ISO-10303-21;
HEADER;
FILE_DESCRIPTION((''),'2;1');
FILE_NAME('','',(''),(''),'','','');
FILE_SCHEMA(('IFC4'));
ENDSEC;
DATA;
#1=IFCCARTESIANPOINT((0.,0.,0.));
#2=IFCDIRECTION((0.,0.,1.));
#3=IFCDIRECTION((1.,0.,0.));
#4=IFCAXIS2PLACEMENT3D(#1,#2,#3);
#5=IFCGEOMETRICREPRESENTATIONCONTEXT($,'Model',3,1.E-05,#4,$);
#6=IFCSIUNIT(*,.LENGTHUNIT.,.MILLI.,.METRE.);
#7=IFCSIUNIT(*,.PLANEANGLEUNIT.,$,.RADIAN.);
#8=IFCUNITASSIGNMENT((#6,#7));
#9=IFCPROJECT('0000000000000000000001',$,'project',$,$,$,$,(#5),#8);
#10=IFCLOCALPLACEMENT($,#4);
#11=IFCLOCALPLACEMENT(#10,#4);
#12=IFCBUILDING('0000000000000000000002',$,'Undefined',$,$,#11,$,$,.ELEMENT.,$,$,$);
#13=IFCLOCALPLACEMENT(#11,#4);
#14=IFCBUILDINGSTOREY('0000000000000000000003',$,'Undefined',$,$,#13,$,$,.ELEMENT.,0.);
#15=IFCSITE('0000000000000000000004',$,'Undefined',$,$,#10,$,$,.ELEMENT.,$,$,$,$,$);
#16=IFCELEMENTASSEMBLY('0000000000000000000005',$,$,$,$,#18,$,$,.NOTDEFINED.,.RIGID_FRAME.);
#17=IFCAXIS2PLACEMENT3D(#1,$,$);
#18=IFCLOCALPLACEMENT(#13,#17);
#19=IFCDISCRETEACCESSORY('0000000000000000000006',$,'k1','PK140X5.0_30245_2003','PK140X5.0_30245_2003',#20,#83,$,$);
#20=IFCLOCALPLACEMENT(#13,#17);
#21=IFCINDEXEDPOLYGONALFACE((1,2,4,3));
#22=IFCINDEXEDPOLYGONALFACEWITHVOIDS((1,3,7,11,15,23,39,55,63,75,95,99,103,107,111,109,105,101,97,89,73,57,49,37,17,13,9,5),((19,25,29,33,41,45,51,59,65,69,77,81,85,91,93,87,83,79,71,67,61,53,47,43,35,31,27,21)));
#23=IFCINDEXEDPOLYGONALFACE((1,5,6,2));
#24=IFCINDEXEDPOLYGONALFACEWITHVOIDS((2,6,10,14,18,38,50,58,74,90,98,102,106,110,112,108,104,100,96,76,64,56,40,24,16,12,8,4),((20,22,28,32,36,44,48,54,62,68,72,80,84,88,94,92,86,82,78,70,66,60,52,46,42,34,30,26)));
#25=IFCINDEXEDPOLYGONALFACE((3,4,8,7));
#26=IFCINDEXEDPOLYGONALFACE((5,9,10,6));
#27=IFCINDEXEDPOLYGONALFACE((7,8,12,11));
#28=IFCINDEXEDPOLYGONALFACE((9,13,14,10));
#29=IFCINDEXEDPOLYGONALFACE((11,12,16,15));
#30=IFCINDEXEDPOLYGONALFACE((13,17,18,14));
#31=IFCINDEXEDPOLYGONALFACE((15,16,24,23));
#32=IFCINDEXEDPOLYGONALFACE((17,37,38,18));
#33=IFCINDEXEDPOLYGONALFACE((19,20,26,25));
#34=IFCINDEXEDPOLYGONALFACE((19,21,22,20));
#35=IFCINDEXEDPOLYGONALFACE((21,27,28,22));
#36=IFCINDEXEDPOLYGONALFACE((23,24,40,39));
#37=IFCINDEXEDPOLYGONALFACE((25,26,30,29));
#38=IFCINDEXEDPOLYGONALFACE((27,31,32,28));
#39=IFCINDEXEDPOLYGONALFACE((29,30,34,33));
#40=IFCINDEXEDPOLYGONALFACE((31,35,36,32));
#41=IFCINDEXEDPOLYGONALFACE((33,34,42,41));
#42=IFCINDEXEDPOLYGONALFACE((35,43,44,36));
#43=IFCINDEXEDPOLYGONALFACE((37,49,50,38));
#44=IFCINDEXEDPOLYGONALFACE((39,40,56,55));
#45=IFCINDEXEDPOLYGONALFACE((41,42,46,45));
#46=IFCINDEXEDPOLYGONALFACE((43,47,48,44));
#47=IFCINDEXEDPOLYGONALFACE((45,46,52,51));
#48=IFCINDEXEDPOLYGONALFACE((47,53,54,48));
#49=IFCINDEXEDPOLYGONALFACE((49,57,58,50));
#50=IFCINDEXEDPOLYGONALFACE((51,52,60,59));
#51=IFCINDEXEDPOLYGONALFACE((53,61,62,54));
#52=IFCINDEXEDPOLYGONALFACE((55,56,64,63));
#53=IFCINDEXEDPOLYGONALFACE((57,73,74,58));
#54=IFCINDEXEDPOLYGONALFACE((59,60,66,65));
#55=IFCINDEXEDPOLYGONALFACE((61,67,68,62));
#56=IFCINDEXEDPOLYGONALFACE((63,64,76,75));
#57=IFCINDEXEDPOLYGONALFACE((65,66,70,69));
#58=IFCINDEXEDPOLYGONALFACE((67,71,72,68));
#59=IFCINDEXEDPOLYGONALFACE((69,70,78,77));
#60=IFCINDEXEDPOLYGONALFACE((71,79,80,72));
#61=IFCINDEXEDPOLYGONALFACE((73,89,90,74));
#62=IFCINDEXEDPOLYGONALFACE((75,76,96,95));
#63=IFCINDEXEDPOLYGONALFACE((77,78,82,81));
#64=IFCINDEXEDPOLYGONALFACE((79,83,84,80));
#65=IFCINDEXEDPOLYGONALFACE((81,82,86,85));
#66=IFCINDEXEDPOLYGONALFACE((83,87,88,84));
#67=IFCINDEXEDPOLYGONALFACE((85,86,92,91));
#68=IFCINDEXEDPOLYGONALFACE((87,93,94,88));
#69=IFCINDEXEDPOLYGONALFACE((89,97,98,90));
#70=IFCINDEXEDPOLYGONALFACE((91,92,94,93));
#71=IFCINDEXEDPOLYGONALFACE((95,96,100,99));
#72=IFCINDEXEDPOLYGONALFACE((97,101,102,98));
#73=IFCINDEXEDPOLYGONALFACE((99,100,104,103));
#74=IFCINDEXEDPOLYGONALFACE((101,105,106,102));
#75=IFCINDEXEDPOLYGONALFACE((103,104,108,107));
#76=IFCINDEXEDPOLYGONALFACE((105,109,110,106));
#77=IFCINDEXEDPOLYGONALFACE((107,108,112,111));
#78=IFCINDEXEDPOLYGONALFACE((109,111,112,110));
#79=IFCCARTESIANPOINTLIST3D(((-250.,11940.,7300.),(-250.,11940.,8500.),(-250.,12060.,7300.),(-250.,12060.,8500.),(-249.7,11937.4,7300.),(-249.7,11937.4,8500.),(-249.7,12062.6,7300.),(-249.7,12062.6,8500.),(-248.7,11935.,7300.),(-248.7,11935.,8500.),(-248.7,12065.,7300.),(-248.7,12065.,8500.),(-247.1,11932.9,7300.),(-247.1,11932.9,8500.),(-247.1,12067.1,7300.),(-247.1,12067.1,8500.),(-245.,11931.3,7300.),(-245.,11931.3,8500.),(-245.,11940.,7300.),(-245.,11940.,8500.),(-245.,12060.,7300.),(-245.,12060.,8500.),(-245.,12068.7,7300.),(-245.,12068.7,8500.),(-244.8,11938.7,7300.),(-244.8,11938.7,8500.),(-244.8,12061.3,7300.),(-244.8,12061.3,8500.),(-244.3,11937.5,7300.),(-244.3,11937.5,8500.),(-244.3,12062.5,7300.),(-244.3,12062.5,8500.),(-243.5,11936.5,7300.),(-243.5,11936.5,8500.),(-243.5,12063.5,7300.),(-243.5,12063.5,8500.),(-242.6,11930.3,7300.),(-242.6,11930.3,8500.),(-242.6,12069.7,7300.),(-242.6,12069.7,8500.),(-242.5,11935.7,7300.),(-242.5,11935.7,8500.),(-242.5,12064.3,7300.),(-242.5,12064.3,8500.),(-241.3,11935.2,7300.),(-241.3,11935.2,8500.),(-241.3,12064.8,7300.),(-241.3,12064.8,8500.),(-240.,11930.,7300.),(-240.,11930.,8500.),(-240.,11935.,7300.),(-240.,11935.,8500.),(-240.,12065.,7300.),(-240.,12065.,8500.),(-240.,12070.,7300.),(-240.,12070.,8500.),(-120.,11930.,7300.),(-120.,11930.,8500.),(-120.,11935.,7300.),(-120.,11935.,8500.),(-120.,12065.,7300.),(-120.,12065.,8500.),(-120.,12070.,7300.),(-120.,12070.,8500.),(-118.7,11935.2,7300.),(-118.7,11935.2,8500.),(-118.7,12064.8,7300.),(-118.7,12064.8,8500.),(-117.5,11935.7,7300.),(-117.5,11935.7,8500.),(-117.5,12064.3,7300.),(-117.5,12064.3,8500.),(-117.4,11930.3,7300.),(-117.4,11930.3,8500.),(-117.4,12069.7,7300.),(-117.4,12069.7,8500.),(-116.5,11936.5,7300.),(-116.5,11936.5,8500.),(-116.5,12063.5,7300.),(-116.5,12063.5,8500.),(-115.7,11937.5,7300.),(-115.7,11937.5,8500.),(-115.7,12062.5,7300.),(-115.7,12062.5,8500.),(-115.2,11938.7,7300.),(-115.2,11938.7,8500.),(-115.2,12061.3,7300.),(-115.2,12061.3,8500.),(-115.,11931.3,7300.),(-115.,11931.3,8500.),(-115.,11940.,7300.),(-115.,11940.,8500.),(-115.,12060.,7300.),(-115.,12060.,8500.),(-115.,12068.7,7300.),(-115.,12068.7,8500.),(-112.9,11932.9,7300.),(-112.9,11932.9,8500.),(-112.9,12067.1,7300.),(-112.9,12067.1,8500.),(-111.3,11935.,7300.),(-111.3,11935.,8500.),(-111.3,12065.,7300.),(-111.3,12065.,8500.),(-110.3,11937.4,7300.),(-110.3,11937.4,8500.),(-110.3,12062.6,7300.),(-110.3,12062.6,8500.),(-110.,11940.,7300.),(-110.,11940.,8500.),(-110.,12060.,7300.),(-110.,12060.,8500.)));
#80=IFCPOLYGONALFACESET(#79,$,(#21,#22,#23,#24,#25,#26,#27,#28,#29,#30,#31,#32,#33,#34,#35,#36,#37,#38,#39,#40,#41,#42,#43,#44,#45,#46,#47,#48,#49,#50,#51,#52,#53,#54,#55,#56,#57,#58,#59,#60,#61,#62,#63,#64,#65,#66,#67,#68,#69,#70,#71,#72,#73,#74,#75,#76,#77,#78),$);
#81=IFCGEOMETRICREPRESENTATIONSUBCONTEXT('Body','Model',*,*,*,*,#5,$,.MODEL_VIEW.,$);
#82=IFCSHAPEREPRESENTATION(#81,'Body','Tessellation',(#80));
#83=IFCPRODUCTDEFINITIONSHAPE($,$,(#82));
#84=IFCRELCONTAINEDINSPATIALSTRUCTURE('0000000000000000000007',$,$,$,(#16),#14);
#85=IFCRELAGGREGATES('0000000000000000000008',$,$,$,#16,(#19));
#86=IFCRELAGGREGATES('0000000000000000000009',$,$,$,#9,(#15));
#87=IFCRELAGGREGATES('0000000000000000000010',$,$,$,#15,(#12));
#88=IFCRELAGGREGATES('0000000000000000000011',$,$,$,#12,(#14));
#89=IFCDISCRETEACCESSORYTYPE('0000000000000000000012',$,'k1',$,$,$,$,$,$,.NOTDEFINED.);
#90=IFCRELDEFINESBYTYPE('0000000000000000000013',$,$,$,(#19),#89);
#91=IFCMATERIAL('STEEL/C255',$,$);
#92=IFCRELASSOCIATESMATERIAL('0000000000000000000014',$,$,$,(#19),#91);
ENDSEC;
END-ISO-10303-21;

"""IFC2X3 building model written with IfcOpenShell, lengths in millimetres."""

from ifc_helpers import new_model, si_unit, frame, origin_with_axes, origin_2d_with_axis, place, context, subcontext, project, spatial, hollow_rectangle, extrude, material, type_object, element, aggregate, save


model = new_model("IFC2X3")

# Units and contexts
model_context = context("Model", 3, precision=1e-05, world=origin_with_axes())
body_context = subcontext(model_context, "Body", "Model", "MODEL_VIEW")
ifc_project = project(units=[si_unit("LENGTHUNIT", "METRE", prefix="MILLI"), si_unit("PLANEANGLEUNIT", "RADIAN")], contexts=[model_context])

# Site, building, storey
site_placement = place(None, origin_with_axes())
site = spatial("IfcSite", under=ifc_project, at=site_placement, Name="Undefined", CompositionType="ELEMENT")
building_placement = place(site_placement, origin_with_axes())
building = spatial("IfcBuilding", under=site, at=building_placement, Name="Undefined", CompositionType="ELEMENT")
storey_placement = place(building_placement, origin_with_axes())
storey = spatial("IfcBuildingStorey", under=building, at=storey_placement, Name="Undefined", CompositionType="ELEMENT", Elevation=0.0)

# Element assembly
assembly_1_placement = place(storey_placement, origin_with_axes())
assembly_1 = element("IfcElementAssembly", 1, at=assembly_1_placement, inside=storey, AssemblyPlace="NOTDEFINED", PredefinedType="RIGID_FRAME")

# Shared definitions
ifc_material_1 = material(Name="STEEL/C255")
discrete_accessory_type = type_object("IfcDiscreteAccessoryType", Name="k1")

# Discrete accessory
discrete_accessory_1_placement = place(assembly_1_placement, frame((-180.0, 12000.0, 7300.0), z_axis=(0.0, 0.0, 1.0), x_axis=(1.0, 0.0, 0.0)))
discrete_accessory_1 = element("IfcDiscreteAccessory", 2, at=discrete_accessory_1_placement, type_object=discrete_accessory_type, material=ifc_material_1, Name="k1", Description="PK140X5.0_30245_2003", ObjectType="PK140X5.0_30245_2003", context=body_context, shape_type="SweptSolid", body=[
    extrude(hollow_rectangle(XDim=140.0, YDim=140.0, WallThickness=5.0, InnerFilletRadius=5.0, OuterFilletRadius=10.0, at=origin_2d_with_axis()), frame((0.0, 0.0, 1200.0), z_axis=(0.0, 0.0, -1.0), x_axis=(0.0, 1.0, 0.0)), (0.0, 0.0, 1.0), 1200.0),
])
aggregate(assembly_1, [discrete_accessory_1])

save(model, "model.ifc")
